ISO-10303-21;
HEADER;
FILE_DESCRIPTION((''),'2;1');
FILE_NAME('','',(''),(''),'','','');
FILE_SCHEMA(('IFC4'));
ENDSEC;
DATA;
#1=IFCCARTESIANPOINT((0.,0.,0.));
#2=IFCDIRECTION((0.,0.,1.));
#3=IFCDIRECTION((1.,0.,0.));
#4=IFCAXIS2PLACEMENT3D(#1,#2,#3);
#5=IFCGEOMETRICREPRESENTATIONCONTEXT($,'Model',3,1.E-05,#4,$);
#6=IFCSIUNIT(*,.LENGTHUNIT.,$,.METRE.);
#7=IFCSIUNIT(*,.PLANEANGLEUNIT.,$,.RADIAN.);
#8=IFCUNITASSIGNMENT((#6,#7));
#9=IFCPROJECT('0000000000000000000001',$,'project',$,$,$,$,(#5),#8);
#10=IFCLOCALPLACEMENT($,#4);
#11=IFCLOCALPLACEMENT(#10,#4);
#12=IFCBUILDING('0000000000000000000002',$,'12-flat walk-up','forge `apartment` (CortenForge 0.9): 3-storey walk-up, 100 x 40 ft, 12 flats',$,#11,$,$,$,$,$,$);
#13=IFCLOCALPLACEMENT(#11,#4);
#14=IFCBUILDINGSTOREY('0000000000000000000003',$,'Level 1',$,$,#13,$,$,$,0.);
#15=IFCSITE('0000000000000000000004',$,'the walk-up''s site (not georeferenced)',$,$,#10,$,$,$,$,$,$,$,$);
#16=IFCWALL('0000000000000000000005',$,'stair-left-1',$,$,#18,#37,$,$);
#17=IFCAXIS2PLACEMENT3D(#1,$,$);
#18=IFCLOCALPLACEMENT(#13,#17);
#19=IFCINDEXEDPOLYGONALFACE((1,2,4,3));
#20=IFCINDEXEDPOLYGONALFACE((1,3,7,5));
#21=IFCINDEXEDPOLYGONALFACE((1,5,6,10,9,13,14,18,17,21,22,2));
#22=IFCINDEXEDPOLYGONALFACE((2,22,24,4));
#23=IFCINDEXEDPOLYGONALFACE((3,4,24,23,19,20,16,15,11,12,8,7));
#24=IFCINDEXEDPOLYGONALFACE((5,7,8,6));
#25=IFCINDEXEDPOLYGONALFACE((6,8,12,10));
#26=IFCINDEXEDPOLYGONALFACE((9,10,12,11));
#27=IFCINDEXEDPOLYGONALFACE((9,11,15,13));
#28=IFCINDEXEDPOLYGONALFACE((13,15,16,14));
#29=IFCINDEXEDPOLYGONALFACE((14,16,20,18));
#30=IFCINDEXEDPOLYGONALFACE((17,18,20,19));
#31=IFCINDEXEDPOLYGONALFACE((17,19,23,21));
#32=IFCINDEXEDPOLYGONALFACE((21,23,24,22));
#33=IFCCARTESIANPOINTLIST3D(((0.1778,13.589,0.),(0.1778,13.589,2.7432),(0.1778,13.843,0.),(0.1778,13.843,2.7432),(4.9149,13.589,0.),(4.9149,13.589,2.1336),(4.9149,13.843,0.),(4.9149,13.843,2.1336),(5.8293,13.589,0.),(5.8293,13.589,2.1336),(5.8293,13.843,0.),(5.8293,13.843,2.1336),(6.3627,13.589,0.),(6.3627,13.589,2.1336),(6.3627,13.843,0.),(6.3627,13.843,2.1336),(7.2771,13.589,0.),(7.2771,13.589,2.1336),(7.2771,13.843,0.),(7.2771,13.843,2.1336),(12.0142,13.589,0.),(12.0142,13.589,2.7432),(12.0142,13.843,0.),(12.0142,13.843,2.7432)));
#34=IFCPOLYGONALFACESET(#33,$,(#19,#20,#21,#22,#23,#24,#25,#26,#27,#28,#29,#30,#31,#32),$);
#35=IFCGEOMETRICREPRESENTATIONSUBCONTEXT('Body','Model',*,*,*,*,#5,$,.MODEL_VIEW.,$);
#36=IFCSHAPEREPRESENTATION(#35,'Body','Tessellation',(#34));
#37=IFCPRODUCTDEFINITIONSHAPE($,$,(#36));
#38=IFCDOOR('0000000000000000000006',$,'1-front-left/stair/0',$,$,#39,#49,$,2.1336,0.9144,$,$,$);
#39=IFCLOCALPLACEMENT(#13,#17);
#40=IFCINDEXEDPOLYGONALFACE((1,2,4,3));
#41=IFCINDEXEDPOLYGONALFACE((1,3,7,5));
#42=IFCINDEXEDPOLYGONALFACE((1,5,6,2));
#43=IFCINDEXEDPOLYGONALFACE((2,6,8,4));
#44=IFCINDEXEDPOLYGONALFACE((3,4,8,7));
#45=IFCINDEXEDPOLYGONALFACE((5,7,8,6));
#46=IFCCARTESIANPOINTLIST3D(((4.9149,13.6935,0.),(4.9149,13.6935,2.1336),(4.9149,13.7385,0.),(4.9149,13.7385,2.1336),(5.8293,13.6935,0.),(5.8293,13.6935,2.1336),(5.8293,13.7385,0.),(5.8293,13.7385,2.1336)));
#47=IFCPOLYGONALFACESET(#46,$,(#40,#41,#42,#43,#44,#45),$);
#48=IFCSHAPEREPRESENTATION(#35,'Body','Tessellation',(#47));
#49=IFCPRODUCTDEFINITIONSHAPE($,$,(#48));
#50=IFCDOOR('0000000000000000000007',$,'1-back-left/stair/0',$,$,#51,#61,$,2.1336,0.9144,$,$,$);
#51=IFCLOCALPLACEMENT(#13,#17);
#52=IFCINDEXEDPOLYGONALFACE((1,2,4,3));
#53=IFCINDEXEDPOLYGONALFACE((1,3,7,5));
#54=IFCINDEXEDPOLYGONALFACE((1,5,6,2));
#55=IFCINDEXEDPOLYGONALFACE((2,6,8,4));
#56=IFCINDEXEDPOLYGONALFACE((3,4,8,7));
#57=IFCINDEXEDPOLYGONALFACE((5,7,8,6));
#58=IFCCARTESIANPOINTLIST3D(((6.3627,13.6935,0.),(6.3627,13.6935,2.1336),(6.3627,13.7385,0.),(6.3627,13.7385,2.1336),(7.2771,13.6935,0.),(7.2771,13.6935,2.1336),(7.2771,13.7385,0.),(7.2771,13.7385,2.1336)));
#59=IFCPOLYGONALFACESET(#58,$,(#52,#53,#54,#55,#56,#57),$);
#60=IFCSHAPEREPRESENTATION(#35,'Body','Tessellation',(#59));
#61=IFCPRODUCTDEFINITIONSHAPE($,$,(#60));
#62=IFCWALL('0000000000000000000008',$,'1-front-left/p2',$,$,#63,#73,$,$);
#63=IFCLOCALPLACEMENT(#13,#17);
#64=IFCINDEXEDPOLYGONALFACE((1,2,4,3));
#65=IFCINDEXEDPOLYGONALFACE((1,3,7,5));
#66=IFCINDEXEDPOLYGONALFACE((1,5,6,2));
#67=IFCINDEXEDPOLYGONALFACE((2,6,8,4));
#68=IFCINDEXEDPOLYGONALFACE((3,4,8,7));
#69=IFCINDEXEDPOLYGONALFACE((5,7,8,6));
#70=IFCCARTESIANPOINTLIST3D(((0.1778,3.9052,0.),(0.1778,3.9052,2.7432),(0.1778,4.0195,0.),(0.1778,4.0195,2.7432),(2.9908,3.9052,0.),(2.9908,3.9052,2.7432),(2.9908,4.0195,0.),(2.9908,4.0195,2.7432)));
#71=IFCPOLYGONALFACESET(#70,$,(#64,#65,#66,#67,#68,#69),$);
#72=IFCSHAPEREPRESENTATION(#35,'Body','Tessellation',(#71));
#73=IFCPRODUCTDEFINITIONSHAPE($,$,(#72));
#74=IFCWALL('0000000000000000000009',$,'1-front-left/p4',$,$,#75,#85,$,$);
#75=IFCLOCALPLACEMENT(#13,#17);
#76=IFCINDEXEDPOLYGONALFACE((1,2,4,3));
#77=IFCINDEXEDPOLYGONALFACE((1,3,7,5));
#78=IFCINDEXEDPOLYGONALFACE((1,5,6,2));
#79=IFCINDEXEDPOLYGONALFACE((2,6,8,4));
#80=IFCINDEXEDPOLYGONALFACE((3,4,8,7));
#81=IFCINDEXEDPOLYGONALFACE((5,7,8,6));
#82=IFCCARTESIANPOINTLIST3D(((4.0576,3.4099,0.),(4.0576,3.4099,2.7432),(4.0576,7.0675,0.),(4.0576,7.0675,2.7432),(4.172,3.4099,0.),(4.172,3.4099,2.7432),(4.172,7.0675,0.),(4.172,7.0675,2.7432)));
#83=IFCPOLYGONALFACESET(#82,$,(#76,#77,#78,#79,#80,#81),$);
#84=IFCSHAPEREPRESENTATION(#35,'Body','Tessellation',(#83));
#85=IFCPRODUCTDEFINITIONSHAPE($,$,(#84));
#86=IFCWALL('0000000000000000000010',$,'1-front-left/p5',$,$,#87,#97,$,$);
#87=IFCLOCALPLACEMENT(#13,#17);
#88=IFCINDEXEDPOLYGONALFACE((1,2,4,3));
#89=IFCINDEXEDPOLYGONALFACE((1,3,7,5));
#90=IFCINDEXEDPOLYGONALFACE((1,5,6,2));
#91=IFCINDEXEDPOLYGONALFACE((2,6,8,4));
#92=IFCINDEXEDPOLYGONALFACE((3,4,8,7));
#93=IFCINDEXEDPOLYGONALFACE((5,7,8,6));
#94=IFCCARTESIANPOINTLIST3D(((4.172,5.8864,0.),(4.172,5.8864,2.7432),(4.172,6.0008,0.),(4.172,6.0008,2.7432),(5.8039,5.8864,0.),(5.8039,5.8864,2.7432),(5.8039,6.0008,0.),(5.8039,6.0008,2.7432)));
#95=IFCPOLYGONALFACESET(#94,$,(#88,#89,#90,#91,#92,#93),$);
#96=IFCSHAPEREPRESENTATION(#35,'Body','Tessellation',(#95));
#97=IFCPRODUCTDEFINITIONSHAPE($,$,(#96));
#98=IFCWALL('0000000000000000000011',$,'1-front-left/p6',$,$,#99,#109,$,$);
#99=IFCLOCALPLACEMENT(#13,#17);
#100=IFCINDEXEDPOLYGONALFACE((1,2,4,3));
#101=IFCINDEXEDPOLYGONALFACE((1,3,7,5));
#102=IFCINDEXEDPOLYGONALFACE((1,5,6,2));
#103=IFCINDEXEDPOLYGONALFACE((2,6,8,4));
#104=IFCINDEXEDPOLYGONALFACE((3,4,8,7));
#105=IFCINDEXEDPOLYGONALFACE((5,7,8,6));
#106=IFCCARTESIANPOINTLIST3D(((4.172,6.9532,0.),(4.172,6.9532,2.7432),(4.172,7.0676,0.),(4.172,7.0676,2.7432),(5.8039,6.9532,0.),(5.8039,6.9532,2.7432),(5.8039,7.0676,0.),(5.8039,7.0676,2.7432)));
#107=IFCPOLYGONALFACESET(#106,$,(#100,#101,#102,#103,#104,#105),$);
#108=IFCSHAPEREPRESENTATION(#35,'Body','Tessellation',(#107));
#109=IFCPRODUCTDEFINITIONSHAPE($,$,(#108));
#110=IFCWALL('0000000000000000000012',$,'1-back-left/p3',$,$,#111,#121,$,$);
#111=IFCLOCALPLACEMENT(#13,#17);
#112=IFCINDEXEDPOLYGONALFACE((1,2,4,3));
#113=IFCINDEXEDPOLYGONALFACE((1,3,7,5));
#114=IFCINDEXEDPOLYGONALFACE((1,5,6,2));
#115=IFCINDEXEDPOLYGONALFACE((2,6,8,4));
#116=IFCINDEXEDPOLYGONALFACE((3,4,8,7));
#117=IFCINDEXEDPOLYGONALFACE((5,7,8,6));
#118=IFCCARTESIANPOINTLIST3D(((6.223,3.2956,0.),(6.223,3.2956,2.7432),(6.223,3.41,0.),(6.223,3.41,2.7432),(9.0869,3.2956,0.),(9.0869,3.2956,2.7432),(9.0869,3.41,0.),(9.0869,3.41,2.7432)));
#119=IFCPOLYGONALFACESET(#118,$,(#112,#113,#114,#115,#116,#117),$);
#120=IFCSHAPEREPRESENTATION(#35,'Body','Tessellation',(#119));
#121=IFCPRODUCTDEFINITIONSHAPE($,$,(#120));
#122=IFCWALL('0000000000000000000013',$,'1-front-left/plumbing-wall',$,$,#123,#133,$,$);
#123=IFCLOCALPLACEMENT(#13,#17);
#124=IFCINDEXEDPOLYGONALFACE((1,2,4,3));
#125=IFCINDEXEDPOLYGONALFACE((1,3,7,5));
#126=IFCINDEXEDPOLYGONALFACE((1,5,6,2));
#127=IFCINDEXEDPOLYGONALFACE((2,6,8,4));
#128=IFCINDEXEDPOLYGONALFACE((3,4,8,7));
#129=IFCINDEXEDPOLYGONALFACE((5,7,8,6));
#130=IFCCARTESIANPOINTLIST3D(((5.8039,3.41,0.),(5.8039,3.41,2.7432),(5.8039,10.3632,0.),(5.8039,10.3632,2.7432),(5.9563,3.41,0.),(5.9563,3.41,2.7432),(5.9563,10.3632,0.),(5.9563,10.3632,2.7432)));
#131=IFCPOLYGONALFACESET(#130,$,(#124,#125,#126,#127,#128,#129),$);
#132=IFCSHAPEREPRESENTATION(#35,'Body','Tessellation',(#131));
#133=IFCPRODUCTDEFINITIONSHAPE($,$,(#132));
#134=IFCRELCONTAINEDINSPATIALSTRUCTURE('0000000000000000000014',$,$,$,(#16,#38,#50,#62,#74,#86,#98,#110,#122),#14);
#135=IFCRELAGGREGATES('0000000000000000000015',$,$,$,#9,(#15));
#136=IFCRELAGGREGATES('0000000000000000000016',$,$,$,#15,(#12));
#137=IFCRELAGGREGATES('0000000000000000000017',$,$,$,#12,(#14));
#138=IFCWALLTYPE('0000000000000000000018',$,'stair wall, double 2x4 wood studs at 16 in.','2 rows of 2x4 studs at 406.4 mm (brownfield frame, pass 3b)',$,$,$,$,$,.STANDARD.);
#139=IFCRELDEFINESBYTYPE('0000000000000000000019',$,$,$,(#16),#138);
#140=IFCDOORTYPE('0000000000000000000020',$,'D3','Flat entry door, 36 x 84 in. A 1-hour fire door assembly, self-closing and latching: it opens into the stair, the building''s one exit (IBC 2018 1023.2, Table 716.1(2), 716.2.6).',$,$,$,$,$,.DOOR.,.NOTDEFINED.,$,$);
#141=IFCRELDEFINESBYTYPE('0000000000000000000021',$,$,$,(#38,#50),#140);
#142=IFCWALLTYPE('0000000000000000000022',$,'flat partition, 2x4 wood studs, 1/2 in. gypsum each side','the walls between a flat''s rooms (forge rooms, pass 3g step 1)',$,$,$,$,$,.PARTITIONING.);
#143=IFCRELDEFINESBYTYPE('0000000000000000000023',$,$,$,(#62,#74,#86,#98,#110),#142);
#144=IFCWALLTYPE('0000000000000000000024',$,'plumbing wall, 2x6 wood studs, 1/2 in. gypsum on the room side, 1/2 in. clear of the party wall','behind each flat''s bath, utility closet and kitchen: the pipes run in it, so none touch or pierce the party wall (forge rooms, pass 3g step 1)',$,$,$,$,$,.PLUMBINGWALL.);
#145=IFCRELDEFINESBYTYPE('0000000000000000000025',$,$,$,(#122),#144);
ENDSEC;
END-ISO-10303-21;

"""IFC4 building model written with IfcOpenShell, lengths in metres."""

from ifc_helpers import new_model, si_unit, frame, frame_2d, origin, origin_with_axes, place, context, subcontext, project, spatial, rectangle, extrude, type_object, element, fill, save


model = new_model("IFC4")

# Units and contexts
model_context = context("Model", 3, precision=1e-05, world=origin_with_axes())
body_context = subcontext(model_context, "Body", "Model", "MODEL_VIEW")
ifc_project = project(units=[si_unit("LENGTHUNIT", "METRE"), si_unit("PLANEANGLEUNIT", "RADIAN")], contexts=[model_context])

# Site, building, storey
site_placement = place(None, origin_with_axes())
site = spatial("IfcSite", under=ifc_project, at=site_placement, Name="the walk-up's site (not georeferenced)")
building_placement = place(site_placement, origin_with_axes())
building = spatial("IfcBuilding", under=site, at=building_placement, Name="12-flat walk-up", Description="forge `apartment` (CortenForge 0.9): 3-storey walk-up, 100 x 40 ft, 12 flats")
storey_placement = place(building_placement, origin_with_axes())
storey = spatial("IfcBuildingStorey", under=building, at=storey_placement, Name="Level 1", Elevation=0.0)

# Wall, openings, doors
wall_type_1 = type_object("IfcWallType", Name="stair wall, double 2x4 wood studs at 16 in.", Description="2 rows of 2x4 studs at 406.4 mm (brownfield frame, pass 3b)", PredefinedType="STANDARD")
wall_1_placement = place(storey_placement, frame((0.1778, 13.589, 0.0), z_axis=(0.0, 0.0, 1.0), x_axis=(1.0, 0.0, 0.0)))
wall_1 = element("IfcWall", 1, at=wall_1_placement, inside=storey, type_object=wall_type_1, Name="stair-left-1", context=body_context, shape_type="SweptSolid", body=[
    extrude(rectangle(XDim=11.8364, YDim=0.254, at=frame_2d((5.9182, 0.127))), origin(), (0.0, 0.0, 1.0), 2.7432),
])
opening_1_placement = place(wall_1_placement, frame((4.7371, 0.0, 0.0), z_axis=(0.0, 0.0, 1.0), x_axis=(1.0, 0.0, 0.0)))
opening_1 = element("IfcOpeningElement", 2, at=opening_1_placement, cuts=wall_1, PredefinedType="OPENING", context=body_context, shape_type="SweptSolid", body=[
    extrude(rectangle(XDim=0.9144, YDim=0.254, at=frame_2d((0.4572, 0.127))), origin(), (0.0, 0.0, 1.0), 2.1336),
])
opening_2_placement = place(wall_1_placement, frame((6.1849, 0.0, 0.0), z_axis=(0.0, 0.0, 1.0), x_axis=(1.0, 0.0, 0.0)))
opening_2 = element("IfcOpeningElement", 3, at=opening_2_placement, cuts=wall_1, PredefinedType="OPENING", context=body_context, shape_type="SweptSolid", body=[
    extrude(rectangle(XDim=0.9144, YDim=0.254, at=frame_2d((0.4572, 0.127))), origin(), (0.0, 0.0, 1.0), 2.1336),
])
door_type = type_object("IfcDoorType", Name="D3", Description="Flat entry door, 36 x 84 in. A 1-hour fire door assembly, self-closing and latching: it opens into the stair, the building's one exit (IBC 2018 1023.2, Table 716.1(2), 716.2.6).", OperationType="NOTDEFINED", PredefinedType="DOOR")
door_1_placement = place(opening_1_placement, frame((0.0, 0.1045, 0.0), z_axis=(0.0, 0.0, 1.0), x_axis=(1.0, 0.0, 0.0)))
door_1 = element("IfcDoor", 4, at=door_1_placement, inside=storey, type_object=door_type, Name="1-front-left/stair/0", OverallHeight=2.1336, OverallWidth=0.9144, context=body_context, shape_type="SweptSolid", body=[
    extrude(rectangle(XDim=0.9144, YDim=0.045, at=frame_2d((0.4572, 0.0225))), origin(), (0.0, 0.0, 1.0), 2.1336),
])
fill(opening_1, door_1)
door_2_placement = place(opening_2_placement, frame((0.0, 0.1045, 0.0), z_axis=(0.0, 0.0, 1.0), x_axis=(1.0, 0.0, 0.0)))
door_2 = element("IfcDoor", 5, at=door_2_placement, inside=storey, type_object=door_type, Name="1-back-left/stair/0", OverallHeight=2.1336, OverallWidth=0.9144, context=body_context, shape_type="SweptSolid", body=[
    extrude(rectangle(XDim=0.9144, YDim=0.045, at=frame_2d((0.4572, 0.0225))), origin(), (0.0, 0.0, 1.0), 2.1336),
])
fill(opening_2, door_2)

# Walls
wall_type_2 = type_object("IfcWallType", Name="flat partition, 2x4 wood studs, 1/2 in. gypsum each side", Description="the walls between a flat's rooms (forge rooms, pass 3g step 1)", PredefinedType="PARTITIONING")
wall_2_placement = place(storey_placement, frame((0.1778, 3.9052, 0.0), z_axis=(0.0, 0.0, 1.0), x_axis=(1.0, 0.0, 0.0)))
element("IfcWall", 6, at=wall_2_placement, inside=storey, type_object=wall_type_2, Name="1-front-left/p2", context=body_context, shape_type="SweptSolid", body=[
    extrude(rectangle(XDim=2.8131, YDim=0.1143, at=frame_2d((1.4065, 0.0571))), origin(), (0.0, 0.0, 1.0), 2.7432),
])
wall_3_placement = place(storey_placement, frame((4.0576, 3.4099, 0.0), z_axis=(0.0, 0.0, 1.0), x_axis=(1.0, 0.0, 0.0)))
element("IfcWall", 7, at=wall_3_placement, inside=storey, type_object=wall_type_2, Name="1-front-left/p4", context=body_context, shape_type="SweptSolid", body=[
    extrude(rectangle(XDim=0.1143, YDim=3.6576, at=frame_2d((0.0572, 1.8288))), origin(), (0.0, 0.0, 1.0), 2.7432),
])
for number, where, z_axis, x_axis, name in (
    (8, (4.1719, 5.8864, 0.0), (0.0, 0.0, 1.0), (1.0, 0.0, 0.0), "1-front-left/p5"),
    (9, (4.1719, 6.9532, 0.0), (0.0, 0.0, 1.0), (1.0, 0.0, 0.0), "1-front-left/p6"),
):
    element("IfcWall", number, at=place(storey_placement, frame(where, z_axis=z_axis, x_axis=x_axis)), inside=storey, type_object=wall_type_2, Name=name, context=body_context, shape_type="SweptSolid", body=[
        extrude(rectangle(XDim=1.6319, YDim=0.1143, at=frame_2d((0.816, 0.0572))), origin(), (0.0, 0.0, 1.0), 2.7432),
    ])
wall_4_placement = place(storey_placement, frame((6.223, 3.2957, 0.0), z_axis=(0.0, 0.0, 1.0), x_axis=(1.0, 0.0, 0.0)))
element("IfcWall", 10, at=wall_4_placement, inside=storey, type_object=wall_type_2, Name="1-back-left/p3", context=body_context, shape_type="SweptSolid", body=[
    extrude(rectangle(XDim=2.8639, YDim=0.1143, at=frame_2d((1.4319, 0.0571))), origin(), (0.0, 0.0, 1.0), 2.7432),
])
wall_type_3 = type_object("IfcWallType", Name="plumbing wall, 2x6 wood studs, 1/2 in. gypsum on the room side, 1/2 in. clear of the party wall", Description="behind each flat's bath, utility closet and kitchen: the pipes run in it, so none touch or pierce the party wall (forge rooms, pass 3g step 1)", PredefinedType="PLUMBINGWALL")
wall_5_placement = place(storey_placement, frame((5.8039, 3.41, 0.0), z_axis=(0.0, 0.0, 1.0), x_axis=(1.0, 0.0, 0.0)))
element("IfcWall", 11, at=wall_5_placement, inside=storey, type_object=wall_type_3, Name="1-front-left/plumbing-wall", context=body_context, shape_type="SweptSolid", body=[
    extrude(rectangle(XDim=0.1524, YDim=6.9533, at=frame_2d((0.0762, 3.4766))), origin(), (0.0, 0.0, 1.0), 2.7432),
])

save(model, "model.ifc")
